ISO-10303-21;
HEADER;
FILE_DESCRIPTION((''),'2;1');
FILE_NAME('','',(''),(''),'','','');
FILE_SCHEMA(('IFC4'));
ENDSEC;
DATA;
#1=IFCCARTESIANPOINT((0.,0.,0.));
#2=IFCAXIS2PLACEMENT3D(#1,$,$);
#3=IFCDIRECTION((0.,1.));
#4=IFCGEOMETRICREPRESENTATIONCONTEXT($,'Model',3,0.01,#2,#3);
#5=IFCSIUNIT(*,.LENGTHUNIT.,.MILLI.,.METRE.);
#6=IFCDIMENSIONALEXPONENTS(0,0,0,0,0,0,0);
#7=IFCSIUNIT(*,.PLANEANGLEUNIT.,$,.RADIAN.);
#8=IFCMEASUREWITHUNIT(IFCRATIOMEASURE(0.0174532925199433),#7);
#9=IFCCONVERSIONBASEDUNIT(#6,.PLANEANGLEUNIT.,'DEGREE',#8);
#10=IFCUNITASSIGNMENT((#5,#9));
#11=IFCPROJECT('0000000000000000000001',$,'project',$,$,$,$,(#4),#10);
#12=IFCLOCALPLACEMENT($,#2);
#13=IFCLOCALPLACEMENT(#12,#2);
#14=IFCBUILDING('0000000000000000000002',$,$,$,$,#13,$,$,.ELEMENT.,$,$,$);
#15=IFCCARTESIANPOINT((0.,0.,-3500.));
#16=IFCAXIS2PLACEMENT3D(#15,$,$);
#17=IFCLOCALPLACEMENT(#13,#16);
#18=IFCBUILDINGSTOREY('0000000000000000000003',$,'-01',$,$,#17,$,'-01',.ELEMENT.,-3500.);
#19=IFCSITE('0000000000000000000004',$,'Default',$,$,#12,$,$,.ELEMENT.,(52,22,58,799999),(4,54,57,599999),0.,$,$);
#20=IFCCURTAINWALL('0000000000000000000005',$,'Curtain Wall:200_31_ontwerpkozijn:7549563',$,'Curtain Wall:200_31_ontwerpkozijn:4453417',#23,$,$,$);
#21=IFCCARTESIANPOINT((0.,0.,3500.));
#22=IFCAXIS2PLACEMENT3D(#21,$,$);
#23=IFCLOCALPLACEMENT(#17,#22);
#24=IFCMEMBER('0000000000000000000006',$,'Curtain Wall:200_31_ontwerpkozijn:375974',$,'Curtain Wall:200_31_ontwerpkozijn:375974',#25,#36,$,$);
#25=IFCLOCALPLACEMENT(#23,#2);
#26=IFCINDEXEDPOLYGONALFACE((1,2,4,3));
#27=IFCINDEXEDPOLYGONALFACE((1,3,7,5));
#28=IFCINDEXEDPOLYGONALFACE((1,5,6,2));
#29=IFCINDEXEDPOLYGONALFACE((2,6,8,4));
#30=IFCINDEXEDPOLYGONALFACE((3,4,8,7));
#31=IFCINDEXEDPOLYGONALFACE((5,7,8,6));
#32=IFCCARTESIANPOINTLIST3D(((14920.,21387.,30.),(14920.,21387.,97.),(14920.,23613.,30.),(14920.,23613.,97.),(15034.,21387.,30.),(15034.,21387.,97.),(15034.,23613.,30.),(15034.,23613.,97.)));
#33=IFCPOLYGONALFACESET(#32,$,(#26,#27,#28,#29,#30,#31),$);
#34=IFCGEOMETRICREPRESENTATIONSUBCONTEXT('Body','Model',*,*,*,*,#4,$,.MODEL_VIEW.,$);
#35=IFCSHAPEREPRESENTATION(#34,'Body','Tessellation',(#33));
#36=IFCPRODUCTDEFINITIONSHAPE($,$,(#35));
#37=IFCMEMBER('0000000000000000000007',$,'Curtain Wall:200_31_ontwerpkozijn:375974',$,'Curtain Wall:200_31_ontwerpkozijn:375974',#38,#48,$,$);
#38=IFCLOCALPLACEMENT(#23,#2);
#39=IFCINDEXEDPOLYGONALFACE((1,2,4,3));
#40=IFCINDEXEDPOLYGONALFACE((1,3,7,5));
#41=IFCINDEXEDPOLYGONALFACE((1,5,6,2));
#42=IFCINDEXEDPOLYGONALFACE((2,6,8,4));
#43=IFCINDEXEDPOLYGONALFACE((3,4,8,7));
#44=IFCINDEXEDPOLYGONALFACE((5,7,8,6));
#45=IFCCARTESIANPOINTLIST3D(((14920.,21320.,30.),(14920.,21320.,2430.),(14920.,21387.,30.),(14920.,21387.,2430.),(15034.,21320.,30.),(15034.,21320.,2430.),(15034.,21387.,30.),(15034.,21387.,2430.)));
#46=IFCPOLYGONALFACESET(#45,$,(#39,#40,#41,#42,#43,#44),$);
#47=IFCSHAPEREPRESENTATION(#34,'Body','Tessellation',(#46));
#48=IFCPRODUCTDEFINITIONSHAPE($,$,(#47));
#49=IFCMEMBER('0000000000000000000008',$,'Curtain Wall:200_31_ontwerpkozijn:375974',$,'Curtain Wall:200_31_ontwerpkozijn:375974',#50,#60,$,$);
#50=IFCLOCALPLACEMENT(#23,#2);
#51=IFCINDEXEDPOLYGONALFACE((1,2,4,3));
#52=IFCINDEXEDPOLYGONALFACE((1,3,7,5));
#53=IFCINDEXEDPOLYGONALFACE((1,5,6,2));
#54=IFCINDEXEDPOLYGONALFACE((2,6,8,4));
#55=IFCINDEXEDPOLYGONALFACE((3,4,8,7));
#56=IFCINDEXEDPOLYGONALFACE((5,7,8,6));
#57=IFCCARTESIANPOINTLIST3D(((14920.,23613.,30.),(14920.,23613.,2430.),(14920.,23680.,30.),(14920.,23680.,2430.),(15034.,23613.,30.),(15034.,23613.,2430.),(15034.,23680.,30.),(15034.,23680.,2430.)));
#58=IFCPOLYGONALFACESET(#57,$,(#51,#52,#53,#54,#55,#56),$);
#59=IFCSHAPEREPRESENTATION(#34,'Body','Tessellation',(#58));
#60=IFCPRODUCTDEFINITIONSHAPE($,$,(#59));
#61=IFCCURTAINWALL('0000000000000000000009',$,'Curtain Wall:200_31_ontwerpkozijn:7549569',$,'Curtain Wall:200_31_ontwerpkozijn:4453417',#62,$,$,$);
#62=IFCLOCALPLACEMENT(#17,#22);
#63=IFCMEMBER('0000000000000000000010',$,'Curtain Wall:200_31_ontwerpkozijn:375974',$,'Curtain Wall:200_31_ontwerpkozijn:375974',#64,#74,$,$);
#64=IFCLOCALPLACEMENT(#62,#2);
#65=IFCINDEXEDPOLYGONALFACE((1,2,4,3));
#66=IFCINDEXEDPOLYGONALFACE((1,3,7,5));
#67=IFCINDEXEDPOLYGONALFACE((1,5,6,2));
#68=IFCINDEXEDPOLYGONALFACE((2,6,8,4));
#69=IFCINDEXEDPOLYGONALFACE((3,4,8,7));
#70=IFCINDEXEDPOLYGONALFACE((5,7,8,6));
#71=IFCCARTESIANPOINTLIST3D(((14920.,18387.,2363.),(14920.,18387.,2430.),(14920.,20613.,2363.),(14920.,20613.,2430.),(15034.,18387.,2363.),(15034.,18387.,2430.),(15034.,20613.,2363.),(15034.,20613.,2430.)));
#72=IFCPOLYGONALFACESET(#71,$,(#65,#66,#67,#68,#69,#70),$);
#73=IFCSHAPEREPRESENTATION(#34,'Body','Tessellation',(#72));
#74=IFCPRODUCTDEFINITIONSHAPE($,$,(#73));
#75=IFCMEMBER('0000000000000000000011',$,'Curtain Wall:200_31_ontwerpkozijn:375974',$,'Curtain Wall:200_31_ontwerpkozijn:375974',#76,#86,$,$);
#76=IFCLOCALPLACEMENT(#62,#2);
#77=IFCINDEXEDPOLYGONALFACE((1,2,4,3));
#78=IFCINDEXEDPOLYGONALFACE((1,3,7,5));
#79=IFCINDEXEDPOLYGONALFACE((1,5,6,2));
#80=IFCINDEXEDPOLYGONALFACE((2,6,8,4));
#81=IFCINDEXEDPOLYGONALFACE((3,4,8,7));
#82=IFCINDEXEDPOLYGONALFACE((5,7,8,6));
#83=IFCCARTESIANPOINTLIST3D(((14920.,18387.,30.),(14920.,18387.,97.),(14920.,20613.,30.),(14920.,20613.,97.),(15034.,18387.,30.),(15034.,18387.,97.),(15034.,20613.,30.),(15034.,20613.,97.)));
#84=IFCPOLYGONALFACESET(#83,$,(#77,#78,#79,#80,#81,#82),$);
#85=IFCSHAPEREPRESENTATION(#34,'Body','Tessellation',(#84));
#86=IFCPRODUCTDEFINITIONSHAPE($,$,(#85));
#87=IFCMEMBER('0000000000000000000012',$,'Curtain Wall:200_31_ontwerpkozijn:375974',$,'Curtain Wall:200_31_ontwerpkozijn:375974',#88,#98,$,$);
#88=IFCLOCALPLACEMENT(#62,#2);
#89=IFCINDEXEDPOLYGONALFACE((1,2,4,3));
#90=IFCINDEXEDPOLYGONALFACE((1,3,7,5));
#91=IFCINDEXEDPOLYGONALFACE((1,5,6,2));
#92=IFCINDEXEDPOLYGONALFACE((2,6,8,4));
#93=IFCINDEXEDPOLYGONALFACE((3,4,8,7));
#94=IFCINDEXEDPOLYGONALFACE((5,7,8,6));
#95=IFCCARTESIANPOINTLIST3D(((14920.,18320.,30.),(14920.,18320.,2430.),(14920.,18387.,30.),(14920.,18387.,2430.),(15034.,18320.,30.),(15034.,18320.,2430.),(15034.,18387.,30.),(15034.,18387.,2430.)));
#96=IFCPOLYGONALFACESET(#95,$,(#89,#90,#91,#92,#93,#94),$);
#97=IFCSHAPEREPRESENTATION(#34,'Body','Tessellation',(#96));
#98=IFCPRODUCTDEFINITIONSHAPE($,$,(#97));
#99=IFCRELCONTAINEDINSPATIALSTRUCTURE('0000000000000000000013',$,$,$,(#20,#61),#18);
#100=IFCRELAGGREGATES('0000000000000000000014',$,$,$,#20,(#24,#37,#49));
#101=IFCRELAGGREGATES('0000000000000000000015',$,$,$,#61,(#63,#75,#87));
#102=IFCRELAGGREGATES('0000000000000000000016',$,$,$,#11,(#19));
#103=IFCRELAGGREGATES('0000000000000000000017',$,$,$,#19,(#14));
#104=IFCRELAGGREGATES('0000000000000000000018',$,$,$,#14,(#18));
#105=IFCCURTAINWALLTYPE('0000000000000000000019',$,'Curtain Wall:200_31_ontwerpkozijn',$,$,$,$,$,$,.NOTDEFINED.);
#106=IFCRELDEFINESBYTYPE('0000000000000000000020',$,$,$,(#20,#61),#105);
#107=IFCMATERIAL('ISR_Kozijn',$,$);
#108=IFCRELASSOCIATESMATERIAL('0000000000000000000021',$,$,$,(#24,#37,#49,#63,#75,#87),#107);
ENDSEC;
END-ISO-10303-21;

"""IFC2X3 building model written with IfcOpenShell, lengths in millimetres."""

from ifc_helpers import new_model, entity, si_unit, converted_unit, direction, frame, frame_2d, origin, origin_2d_with_axis, place, context, subcontext, project, spatial, rectangle, extrude, material, type_object, element, aggregate, save


model = new_model("IFC2X3")

# Units and contexts
model_context = context("Model", 3, precision=0.01, world=origin(), true_north=direction((0.0, 1.0)))
body_context = subcontext(model_context, "Body", "Model", "MODEL_VIEW")
ifc_project = project(units=[si_unit("LENGTHUNIT", "METRE", prefix="MILLI"), converted_unit("PLANEANGLEUNIT", "DEGREE", entity("IfcRatioMeasure", 0.0174532925199433), si_unit("PLANEANGLEUNIT", "RADIAN"), dimensions=[0, 0, 0, 0, 0, 0, 0])], contexts=[model_context])

# Site, building, storey
site_placement = place(None, origin())
site = spatial("IfcSite", under=ifc_project, at=site_placement, Name="Default", CompositionType="ELEMENT", RefLatitude=(52, 22, 58, 799999), RefLongitude=(4, 54, 57, 599999), RefElevation=0.0)
building_placement = place(site_placement, origin())
building = spatial("IfcBuilding", under=site, at=building_placement, CompositionType="ELEMENT")
storey_placement = place(building_placement, frame((0.0, 0.0, -3500.0)))
storey = spatial("IfcBuildingStorey", under=building, at=storey_placement, Name="-01", LongName="-01", CompositionType="ELEMENT", Elevation=-3500.0)

# Curtain walls, members
curtain_wall_type = type_object("IfcCurtainWallType", Name="Curtain Wall:200_31_ontwerpkozijn", PredefinedType="NOTDEFINED")
ifc_material = material(Name="ISR_Kozijn")
curtain_wall_1_placement = place(storey_placement, frame((0.0, 0.0, 3500.0)))
curtain_wall_1 = element("IfcCurtainWall", 1, at=curtain_wall_1_placement, inside=storey, type_object=curtain_wall_type, Name="Curtain Wall:200_31_ontwerpkozijn:7549563", ObjectType="Curtain Wall:200_31_ontwerpkozijn:4453417")
member_1_placement = place(curtain_wall_1_placement, origin())
member_1 = element("IfcMember", 2, at=member_1_placement, material=ifc_material, Name="Curtain Wall:200_31_ontwerpkozijn:375974", ObjectType="Curtain Wall:200_31_ontwerpkozijn:375974", context=body_context, shape_type="SweptSolid", body=[
    extrude(rectangle(XDim=67.0, YDim=114.0, at=origin_2d_with_axis()), frame((14977.0, 23613.0, 63.5), z_axis=(0.0, -1.0, 0.0), x_axis=(0.0, 0.0, -1.0)), (0.0, 0.0, 1.0), 2226.0),
])
member_2_placement = place(curtain_wall_1_placement, origin())
member_2 = element("IfcMember", 3, at=member_2_placement, material=ifc_material, Name="Curtain Wall:200_31_ontwerpkozijn:375974", ObjectType="Curtain Wall:200_31_ontwerpkozijn:375974", context=body_context, shape_type="SweptSolid", body=[
    extrude(rectangle(XDim=114.0, YDim=67.0, at=origin_2d_with_axis()), frame((14977.0, 21353.5, 30.0), z_axis=(0.0, 0.0, 1.0), x_axis=(-1.0, 0.0, 0.0)), (0.0, 0.0, 1.0), 2400.0),
])
member_3_placement = place(curtain_wall_1_placement, origin())
member_3 = element("IfcMember", 4, at=member_3_placement, material=ifc_material, Name="Curtain Wall:200_31_ontwerpkozijn:375974", ObjectType="Curtain Wall:200_31_ontwerpkozijn:375974", context=body_context, shape_type="SweptSolid", body=[
    extrude(rectangle(XDim=114.0, YDim=67.0, at=origin_2d_with_axis()), frame((14977.0, 23646.5, 2430.0), z_axis=(0.0, 0.0, -1.0), x_axis=(-1.0, 0.0, 0.0)), (0.0, 0.0, 1.0), 2400.0),
])
aggregate(curtain_wall_1, [member_1, member_2, member_3])
curtain_wall_2_placement = place(storey_placement, frame((0.0, 0.0, 3500.0)))
curtain_wall_2 = element("IfcCurtainWall", 5, at=curtain_wall_2_placement, inside=storey, type_object=curtain_wall_type, Name="Curtain Wall:200_31_ontwerpkozijn:7549569", ObjectType="Curtain Wall:200_31_ontwerpkozijn:4453417")
member_4_placement = place(curtain_wall_2_placement, origin())
member_4 = element("IfcMember", 6, at=member_4_placement, material=ifc_material, Name="Curtain Wall:200_31_ontwerpkozijn:375974", ObjectType="Curtain Wall:200_31_ontwerpkozijn:375974", context=body_context, shape_type="SweptSolid", body=[
    extrude(rectangle(XDim=67.0, YDim=114.0, at=origin_2d_with_axis()), frame((14977.0, 18387.0, 2396.5), z_axis=(0.0, 1.0, 0.0), x_axis=(0.0, 0.0, -1.0)), (0.0, 0.0, 1.0), 2226.0),
])
member_5_placement = place(curtain_wall_2_placement, origin())
member_5 = element("IfcMember", 7, at=member_5_placement, material=ifc_material, Name="Curtain Wall:200_31_ontwerpkozijn:375974", ObjectType="Curtain Wall:200_31_ontwerpkozijn:375974", context=body_context, shape_type="SweptSolid", body=[
    extrude(rectangle(XDim=67.0, YDim=114.0, at=origin_2d_with_axis()), frame((14977.0, 20613.0, 63.5), z_axis=(0.0, -1.0, 0.0), x_axis=(0.0, 0.0, -1.0)), (0.0, 0.0, 1.0), 2226.0),
])
member_6_placement = place(curtain_wall_2_placement, origin())
member_6 = element("IfcMember", 8, at=member_6_placement, material=ifc_material, Name="Curtain Wall:200_31_ontwerpkozijn:375974", ObjectType="Curtain Wall:200_31_ontwerpkozijn:375974", context=body_context, shape_type="SweptSolid", body=[
    extrude(rectangle(XDim=114.0, YDim=67.0, at=frame_2d((0.0, 0.0), x_axis=(1.0, 0.0))), frame((14977.0, 18353.5, 30.0), z_axis=(0.0, 0.0, 1.0), x_axis=(-1.0, 0.0, 0.0)), (0.0, 0.0, 1.0), 2400.0),
])
aggregate(curtain_wall_2, [member_4, member_5, member_6])

save(model, "model.ifc")
